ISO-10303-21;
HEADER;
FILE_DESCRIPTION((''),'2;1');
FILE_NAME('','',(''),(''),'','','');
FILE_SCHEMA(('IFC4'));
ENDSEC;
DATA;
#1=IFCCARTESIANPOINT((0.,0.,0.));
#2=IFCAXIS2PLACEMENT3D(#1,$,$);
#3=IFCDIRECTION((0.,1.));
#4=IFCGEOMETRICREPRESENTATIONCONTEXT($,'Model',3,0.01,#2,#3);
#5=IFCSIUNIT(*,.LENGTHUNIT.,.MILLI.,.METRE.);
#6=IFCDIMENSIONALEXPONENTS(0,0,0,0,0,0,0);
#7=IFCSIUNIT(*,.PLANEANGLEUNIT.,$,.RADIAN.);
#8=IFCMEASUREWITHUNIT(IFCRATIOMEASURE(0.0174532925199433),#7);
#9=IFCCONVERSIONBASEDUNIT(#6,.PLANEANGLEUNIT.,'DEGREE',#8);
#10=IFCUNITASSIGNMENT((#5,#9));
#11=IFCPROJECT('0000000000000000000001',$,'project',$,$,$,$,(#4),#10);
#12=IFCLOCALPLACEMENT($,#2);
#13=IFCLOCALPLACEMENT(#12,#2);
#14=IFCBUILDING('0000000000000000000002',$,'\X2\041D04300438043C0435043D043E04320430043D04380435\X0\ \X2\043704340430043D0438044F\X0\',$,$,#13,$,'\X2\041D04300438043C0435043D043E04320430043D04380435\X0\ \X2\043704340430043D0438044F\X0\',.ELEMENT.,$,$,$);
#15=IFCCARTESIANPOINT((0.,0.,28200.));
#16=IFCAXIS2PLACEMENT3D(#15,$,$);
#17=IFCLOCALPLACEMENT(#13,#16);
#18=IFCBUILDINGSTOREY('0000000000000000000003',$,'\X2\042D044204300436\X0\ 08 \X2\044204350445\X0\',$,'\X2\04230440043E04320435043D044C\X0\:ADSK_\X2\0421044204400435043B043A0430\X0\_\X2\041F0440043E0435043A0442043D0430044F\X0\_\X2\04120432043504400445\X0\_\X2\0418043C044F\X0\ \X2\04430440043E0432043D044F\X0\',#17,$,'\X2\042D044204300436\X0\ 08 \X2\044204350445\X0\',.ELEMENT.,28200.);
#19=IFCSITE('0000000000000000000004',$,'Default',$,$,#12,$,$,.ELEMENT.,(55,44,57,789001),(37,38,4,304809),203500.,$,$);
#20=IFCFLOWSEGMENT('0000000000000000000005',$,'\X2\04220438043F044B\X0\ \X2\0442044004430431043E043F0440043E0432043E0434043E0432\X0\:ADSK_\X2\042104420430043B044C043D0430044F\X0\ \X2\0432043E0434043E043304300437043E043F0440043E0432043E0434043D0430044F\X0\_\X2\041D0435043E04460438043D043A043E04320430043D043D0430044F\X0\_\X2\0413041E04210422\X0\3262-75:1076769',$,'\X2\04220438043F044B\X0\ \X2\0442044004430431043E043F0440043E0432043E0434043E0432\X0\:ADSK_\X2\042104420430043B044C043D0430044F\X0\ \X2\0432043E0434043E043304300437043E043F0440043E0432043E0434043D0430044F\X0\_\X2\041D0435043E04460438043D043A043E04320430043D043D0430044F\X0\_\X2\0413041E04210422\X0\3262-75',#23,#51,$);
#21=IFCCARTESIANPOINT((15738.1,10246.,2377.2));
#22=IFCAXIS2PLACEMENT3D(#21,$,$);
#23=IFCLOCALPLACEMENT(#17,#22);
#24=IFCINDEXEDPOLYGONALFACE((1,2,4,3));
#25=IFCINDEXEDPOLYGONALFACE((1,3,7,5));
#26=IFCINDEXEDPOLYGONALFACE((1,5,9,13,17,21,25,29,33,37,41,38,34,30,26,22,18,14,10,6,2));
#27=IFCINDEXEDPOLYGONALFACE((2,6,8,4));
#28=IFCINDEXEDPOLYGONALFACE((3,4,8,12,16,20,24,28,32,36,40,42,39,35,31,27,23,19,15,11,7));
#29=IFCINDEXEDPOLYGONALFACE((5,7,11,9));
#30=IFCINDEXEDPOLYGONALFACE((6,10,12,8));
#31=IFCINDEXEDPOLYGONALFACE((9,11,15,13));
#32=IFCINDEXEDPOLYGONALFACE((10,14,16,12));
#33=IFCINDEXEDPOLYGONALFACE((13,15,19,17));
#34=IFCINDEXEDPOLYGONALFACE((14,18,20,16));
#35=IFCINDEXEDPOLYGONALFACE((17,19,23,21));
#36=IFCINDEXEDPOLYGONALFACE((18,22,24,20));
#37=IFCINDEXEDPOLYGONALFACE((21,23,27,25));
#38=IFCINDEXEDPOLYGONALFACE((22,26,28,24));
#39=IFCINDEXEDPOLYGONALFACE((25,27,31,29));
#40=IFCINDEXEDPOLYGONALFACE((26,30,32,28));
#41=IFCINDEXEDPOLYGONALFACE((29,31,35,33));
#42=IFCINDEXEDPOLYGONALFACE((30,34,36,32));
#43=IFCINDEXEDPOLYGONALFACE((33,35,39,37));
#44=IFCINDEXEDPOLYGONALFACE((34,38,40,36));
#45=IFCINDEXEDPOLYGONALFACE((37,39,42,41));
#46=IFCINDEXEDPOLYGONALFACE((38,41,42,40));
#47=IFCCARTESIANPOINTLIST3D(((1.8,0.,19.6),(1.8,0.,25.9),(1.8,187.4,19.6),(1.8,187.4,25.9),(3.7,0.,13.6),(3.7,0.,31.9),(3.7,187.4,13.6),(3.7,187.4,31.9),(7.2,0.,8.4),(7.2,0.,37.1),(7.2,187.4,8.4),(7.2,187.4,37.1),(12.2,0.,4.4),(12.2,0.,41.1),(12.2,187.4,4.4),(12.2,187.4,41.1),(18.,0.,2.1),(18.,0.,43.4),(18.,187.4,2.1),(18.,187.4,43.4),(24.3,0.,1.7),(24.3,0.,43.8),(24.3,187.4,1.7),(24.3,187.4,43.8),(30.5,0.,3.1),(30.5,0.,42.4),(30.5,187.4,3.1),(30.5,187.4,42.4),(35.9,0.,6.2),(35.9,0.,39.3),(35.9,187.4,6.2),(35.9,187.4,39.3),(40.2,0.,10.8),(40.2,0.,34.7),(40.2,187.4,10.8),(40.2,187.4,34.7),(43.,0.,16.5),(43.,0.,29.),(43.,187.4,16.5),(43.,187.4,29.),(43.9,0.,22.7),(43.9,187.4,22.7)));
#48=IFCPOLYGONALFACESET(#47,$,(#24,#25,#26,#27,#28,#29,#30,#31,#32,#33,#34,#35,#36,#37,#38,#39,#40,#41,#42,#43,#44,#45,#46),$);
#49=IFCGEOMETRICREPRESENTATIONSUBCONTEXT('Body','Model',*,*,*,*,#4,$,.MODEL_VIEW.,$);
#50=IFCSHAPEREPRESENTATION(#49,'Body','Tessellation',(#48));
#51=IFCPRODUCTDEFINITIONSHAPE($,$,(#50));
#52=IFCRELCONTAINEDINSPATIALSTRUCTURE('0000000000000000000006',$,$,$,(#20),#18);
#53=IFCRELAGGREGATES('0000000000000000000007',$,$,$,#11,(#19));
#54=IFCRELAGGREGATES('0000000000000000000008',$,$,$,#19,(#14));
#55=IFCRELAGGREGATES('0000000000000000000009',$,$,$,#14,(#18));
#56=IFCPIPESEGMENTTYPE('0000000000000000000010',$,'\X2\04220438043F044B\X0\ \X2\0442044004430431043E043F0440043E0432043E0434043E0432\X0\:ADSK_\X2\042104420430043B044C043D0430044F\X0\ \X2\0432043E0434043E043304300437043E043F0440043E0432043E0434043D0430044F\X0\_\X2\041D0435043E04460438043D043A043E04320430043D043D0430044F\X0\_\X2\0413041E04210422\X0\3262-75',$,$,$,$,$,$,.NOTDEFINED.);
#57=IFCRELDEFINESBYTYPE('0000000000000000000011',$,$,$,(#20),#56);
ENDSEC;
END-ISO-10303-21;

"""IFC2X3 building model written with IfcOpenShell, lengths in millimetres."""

from ifc_helpers import new_model, entity, si_unit, converted_unit, direction, frame, origin, origin_2d_with_axis, place, context, subcontext, project, spatial, circle, extrude, type_object, element, save


model = new_model("IFC2X3")

# Units and contexts
model_context = context("Model", 3, precision=0.01, world=origin(), true_north=direction((0.0, 1.0)))
body_context = subcontext(model_context, "Body", "Model", "MODEL_VIEW")
ifc_project = project(units=[si_unit("LENGTHUNIT", "METRE", prefix="MILLI"), converted_unit("PLANEANGLEUNIT", "DEGREE", entity("IfcRatioMeasure", 0.0174532925199433), si_unit("PLANEANGLEUNIT", "RADIAN"), dimensions=[0, 0, 0, 0, 0, 0, 0])], contexts=[model_context])

# Site, building, storey
site_placement = place(None, origin())
site = spatial("IfcSite", under=ifc_project, at=site_placement, Name="Default", CompositionType="ELEMENT", RefLatitude=(55, 44, 57, 789001), RefLongitude=(37, 38, 4, 304809), RefElevation=203500.0)
building_placement = place(site_placement, origin())
building = spatial("IfcBuilding", under=site, at=building_placement, Name="Наименование здания", LongName="Наименование здания", CompositionType="ELEMENT")
storey_placement = place(building_placement, frame((0.0, 0.0, 28200.0)))
storey = spatial("IfcBuildingStorey", under=building, at=storey_placement, Name="Этаж 08 тех", ObjectType="Уровень:ADSK_Стрелка_Проектная_Вверх_Имя уровня", LongName="Этаж 08 тех", CompositionType="ELEMENT", Elevation=28200.0)

# Flow segment
pipe_segment_type = type_object("IfcPipeSegmentType", Name="Типы трубопроводов:ADSK_Стальная водогазопроводная_Неоцинкованная_ГОСТ3262-75", PredefinedType="NOTDEFINED")
flow_segment_1_placement = place(storey_placement, frame((15738.1, 10246.0, 2377.2)))
element("IfcFlowSegment", 1, at=flow_segment_1_placement, inside=storey, type_object=pipe_segment_type, Name="Типы трубопроводов:ADSK_Стальная водогазопроводная_Неоцинкованная_ГОСТ3262-75:1076769", ObjectType="Типы трубопроводов:ADSK_Стальная водогазопроводная_Неоцинкованная_ГОСТ3262-75", context=body_context, shape_type="SweptSolid", body=[
    extrude(circle(Radius=21.1, at=origin_2d_with_axis()), frame((22.8, 0.0, 22.8), z_axis=(0.0, 1.0, 0.0), x_axis=(1.0, 0.0, 0.0)), (0.0, 0.0, 1.0), 187.4),
])

save(model, "model.ifc")
